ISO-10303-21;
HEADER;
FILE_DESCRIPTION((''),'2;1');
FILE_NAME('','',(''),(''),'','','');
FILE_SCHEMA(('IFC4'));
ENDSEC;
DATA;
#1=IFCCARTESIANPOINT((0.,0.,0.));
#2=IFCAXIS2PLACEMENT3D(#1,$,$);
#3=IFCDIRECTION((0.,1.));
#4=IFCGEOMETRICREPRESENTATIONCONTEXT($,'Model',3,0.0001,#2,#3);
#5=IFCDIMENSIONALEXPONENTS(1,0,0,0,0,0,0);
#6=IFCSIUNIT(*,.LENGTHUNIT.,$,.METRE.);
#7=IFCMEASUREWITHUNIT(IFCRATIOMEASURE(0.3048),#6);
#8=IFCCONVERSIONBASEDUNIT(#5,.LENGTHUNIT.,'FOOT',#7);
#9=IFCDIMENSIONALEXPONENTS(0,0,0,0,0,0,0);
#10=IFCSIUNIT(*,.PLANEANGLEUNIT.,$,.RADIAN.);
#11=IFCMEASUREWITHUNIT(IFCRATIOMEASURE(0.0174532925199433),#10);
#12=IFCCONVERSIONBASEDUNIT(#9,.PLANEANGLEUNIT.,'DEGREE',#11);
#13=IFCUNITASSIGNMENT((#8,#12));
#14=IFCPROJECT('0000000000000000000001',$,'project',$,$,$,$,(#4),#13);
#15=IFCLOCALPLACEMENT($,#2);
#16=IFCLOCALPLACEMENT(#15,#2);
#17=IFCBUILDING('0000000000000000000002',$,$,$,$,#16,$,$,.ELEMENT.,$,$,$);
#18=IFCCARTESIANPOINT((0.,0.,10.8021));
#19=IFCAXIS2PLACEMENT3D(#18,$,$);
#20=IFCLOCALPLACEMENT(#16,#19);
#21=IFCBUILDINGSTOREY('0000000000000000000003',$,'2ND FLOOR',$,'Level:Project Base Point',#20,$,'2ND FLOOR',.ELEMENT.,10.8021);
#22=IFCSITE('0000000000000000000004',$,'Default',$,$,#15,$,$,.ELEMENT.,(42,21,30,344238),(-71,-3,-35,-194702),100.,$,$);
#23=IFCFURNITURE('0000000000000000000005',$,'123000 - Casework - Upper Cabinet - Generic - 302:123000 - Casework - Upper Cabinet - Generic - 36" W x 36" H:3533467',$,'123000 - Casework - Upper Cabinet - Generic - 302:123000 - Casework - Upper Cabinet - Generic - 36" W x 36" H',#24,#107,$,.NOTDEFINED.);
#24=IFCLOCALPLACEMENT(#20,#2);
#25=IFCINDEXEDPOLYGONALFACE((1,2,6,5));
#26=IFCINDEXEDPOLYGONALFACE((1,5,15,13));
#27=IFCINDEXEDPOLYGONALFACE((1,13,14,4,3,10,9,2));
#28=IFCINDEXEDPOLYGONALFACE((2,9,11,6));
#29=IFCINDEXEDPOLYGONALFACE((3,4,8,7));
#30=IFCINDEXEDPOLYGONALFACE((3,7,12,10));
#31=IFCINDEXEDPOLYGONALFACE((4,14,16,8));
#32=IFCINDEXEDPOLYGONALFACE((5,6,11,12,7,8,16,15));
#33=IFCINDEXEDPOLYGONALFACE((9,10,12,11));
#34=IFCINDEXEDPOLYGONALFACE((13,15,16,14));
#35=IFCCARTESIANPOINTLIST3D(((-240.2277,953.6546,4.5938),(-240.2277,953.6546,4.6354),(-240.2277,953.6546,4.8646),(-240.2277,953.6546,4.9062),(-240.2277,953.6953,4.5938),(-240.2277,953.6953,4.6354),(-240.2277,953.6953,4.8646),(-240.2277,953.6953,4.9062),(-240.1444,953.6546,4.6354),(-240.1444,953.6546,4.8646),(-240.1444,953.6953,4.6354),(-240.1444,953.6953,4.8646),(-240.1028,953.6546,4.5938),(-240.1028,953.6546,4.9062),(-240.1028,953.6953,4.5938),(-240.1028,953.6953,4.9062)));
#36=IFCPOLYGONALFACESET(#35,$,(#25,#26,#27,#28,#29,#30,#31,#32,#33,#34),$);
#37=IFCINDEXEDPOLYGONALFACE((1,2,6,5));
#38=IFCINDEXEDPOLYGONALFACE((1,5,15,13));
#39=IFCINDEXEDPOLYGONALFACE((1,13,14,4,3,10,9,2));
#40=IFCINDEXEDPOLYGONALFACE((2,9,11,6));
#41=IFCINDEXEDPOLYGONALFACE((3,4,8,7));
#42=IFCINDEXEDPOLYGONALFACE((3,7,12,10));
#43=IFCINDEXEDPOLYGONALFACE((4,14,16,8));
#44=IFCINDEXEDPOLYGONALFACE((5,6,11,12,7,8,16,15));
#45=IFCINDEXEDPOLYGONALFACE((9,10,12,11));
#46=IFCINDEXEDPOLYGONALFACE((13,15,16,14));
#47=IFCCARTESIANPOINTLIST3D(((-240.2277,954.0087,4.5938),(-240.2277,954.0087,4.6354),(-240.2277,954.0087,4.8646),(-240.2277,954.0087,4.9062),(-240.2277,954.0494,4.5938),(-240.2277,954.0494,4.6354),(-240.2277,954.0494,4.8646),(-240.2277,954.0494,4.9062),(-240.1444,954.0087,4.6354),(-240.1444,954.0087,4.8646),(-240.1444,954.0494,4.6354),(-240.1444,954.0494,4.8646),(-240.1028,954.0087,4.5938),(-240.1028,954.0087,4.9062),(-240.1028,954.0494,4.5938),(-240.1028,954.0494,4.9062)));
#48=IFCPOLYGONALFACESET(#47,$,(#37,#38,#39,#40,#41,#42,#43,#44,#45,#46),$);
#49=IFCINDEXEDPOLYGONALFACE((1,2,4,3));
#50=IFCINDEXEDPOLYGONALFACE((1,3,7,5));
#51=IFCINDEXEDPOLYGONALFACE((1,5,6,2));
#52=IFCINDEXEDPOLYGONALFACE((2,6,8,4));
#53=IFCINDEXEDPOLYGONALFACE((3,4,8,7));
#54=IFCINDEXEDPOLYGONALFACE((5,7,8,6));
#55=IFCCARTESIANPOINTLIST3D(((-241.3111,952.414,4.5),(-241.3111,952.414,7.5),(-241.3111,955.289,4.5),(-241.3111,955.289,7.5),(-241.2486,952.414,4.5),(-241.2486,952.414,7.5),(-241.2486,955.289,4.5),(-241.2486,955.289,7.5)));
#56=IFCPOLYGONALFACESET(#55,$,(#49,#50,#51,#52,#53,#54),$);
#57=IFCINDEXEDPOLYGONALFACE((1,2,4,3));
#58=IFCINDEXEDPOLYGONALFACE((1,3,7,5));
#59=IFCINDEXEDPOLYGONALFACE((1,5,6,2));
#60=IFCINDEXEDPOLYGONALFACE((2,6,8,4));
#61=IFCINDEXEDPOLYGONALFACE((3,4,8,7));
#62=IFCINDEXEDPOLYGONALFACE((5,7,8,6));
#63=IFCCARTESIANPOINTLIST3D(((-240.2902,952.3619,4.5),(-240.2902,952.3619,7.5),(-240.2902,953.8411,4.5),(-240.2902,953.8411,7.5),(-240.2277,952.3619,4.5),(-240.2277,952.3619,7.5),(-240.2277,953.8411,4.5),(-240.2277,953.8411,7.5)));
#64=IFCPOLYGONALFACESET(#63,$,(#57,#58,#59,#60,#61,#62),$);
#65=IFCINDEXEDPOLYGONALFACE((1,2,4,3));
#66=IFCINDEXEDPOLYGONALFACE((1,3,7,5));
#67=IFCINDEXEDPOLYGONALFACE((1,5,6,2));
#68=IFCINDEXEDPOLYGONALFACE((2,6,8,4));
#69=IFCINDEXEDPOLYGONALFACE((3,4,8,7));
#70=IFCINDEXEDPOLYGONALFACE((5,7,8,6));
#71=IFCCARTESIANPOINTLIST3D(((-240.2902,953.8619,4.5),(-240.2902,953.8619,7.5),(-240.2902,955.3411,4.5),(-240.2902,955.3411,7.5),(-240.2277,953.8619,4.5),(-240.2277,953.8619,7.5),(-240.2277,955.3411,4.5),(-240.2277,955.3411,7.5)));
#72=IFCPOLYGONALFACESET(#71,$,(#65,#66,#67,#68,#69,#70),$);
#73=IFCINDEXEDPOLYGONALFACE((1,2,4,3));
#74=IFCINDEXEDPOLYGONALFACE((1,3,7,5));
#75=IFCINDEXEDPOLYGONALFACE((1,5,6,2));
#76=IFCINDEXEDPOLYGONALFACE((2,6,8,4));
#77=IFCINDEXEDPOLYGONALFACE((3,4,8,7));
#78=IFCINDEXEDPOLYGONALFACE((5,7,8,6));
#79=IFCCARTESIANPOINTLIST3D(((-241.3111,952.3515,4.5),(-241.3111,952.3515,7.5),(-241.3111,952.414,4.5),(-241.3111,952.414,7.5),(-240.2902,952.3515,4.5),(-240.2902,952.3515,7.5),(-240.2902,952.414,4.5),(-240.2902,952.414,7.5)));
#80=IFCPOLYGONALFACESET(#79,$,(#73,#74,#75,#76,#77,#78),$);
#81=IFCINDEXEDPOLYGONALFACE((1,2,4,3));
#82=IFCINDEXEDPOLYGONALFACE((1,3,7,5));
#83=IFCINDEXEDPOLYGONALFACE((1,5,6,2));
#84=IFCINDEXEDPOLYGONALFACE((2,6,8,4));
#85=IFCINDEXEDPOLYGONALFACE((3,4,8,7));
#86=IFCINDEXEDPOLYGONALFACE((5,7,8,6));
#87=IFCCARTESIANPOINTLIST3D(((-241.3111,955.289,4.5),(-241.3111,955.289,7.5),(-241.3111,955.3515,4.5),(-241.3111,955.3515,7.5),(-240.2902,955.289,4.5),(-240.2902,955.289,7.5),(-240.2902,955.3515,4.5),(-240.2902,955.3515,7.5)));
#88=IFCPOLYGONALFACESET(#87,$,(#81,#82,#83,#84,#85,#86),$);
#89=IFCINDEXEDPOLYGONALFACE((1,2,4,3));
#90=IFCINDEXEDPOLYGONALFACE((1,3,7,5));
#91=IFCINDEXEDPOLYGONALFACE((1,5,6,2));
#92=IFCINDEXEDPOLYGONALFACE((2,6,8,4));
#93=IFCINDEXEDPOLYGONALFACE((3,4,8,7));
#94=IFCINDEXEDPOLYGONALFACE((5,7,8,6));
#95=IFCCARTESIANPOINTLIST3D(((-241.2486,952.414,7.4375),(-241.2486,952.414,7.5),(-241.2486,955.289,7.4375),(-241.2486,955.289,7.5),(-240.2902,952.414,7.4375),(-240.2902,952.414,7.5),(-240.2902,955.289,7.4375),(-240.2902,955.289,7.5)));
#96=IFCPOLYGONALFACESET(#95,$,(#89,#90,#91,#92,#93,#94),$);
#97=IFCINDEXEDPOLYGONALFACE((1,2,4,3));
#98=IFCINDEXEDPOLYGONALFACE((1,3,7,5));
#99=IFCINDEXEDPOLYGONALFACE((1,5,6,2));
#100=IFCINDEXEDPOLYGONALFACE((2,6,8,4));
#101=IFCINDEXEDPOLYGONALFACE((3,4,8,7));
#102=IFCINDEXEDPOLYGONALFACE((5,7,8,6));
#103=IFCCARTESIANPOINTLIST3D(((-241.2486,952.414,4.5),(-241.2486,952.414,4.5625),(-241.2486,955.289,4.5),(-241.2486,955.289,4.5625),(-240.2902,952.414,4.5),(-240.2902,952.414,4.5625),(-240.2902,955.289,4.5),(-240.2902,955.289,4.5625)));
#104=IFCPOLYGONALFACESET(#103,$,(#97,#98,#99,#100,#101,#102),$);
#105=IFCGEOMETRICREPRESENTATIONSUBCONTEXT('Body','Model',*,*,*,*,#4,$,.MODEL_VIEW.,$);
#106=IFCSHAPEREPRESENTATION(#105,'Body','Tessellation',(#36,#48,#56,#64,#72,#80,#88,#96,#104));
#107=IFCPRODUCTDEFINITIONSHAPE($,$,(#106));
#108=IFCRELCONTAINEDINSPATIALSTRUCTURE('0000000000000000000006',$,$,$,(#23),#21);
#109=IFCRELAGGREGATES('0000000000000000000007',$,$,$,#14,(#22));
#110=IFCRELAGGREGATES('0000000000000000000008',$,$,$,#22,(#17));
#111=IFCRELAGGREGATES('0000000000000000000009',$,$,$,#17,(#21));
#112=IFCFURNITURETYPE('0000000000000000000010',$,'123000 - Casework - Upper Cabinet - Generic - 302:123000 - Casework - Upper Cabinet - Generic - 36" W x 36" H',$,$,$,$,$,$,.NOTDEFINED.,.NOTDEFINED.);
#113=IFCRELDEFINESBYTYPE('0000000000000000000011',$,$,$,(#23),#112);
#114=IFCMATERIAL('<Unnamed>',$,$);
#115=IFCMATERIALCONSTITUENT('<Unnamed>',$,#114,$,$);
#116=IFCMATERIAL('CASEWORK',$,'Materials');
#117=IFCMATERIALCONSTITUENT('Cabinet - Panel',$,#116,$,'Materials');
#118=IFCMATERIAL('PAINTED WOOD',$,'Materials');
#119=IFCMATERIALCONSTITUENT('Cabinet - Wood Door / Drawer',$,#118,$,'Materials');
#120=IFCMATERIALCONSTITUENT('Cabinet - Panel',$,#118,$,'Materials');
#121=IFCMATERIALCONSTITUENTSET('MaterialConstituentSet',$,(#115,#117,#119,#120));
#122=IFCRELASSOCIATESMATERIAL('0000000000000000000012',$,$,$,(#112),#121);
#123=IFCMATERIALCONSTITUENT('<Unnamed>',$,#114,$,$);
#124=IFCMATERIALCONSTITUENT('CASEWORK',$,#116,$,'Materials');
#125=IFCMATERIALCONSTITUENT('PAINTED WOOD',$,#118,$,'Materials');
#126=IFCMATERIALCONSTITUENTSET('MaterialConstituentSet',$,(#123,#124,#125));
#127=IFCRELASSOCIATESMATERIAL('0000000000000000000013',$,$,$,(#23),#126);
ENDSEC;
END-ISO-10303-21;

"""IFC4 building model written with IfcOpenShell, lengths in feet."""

from ifc_helpers import new_model, entity, si_unit, converted_unit, direction, frame, frame_2d, origin, origin_2d_with_axis, place, context, subcontext, project, spatial, polyline, rectangle, outline, extrude, source, transform, mapped, material, constituent, constituent_set, type_object, type_shapes, element, save


model = new_model("IFC4")

# Units and contexts
model_context = context("Model", 3, precision=0.0001, world=origin(), true_north=direction((0.0, 1.0)))
body_context = subcontext(model_context, "Body", "Model", "MODEL_VIEW")
ifc_project = project(units=[converted_unit("LENGTHUNIT", "FOOT", entity("IfcRatioMeasure", 0.3048), si_unit("LENGTHUNIT", "METRE"), dimensions=[1, 0, 0, 0, 0, 0, 0]), converted_unit("PLANEANGLEUNIT", "DEGREE", entity("IfcRatioMeasure", 0.0174532925199433), si_unit("PLANEANGLEUNIT", "RADIAN"), dimensions=[0, 0, 0, 0, 0, 0, 0])], contexts=[model_context])

# Site, building, storey
site_placement = place(None, origin())
site = spatial("IfcSite", under=ifc_project, at=site_placement, Name="Default", CompositionType="ELEMENT", RefLatitude=(42, 21, 30, 344238), RefLongitude=(-71, -3, -35, -194702), RefElevation=100.0)
building_placement = place(site_placement, origin())
building = spatial("IfcBuilding", under=site, at=building_placement, CompositionType="ELEMENT")
storey_placement = place(building_placement, frame((0.0, 0.0, 10.8021)))
storey = spatial("IfcBuildingStorey", under=building, at=storey_placement, Name="2ND FLOOR", ObjectType="Level:Project Base Point", LongName="2ND FLOOR", CompositionType="ELEMENT", Elevation=10.8021)

# Shared definitions
ifc_material_1 = material(Name="PAINTED WOOD", Category="Materials")
ifc_material_2 = material(Name="CASEWORK", Category="Materials")

# Furniture
ifc_material_3 = material(Name="<Unnamed>")
ifc_constituent_1 = constituent(ifc_material_3, Name="<Unnamed>")
ifc_constituent_2 = constituent(ifc_material_2, Name="CASEWORK", Category="Materials")
ifc_constituent_3 = constituent(ifc_material_1, Name="PAINTED WOOD", Category="Materials")
ifc_constituent_set_1 = constituent_set(constituents=[ifc_constituent_1, ifc_constituent_2, ifc_constituent_3], Name="MaterialConstituentSet")
ifc_constituent_4 = constituent(ifc_material_3, Name="<Unnamed>")
ifc_constituent_5 = constituent(ifc_material_2, Name="Cabinet - Panel", Category="Materials")
ifc_constituent_6 = constituent(ifc_material_1, Name="Cabinet - Wood Door / Drawer", Category="Materials")
ifc_constituent_7 = constituent(ifc_material_1, Name="Cabinet - Panel", Category="Materials")
ifc_constituent_set_2 = constituent_set(constituents=[ifc_constituent_4, ifc_constituent_5, ifc_constituent_6, ifc_constituent_7], Name="MaterialConstituentSet")
furniture_type_1 = type_object("IfcFurnitureType", Name="123000 - Casework - Upper Cabinet - Generic - 302:123000 - Casework - Upper Cabinet - Generic - 36\" W x 36\" H", AssemblyPlace="NOTDEFINED", PredefinedType="NOTDEFINED", material=ifc_constituent_set_2)
shared_shape_1 = source(origin(), body_context, "Body", "SweptSolid", [
    extrude(outline(polyline([(0.1146, -0.0521), (0.1562, -0.0521), (0.1562, 0.0729), (-0.1562, 0.0729), (-0.1562, -0.0521), (-0.1146, -0.0521), (-0.1146, 0.0313), (0.1146, 0.0313), (0.1146, -0.0521)])), frame((1.303, 0.0729, 0.25), z_axis=(1.0, 0.0, 0.0), x_axis=(0.0, 0.0, 1.0)), (0.0, 0.0, 1.0), 0.0407),
    extrude(outline(polyline([(0.1146, -0.0521), (0.1562, -0.0521), (0.1562, 0.0729), (-0.1562, 0.0729), (-0.1562, -0.0521), (-0.1146, -0.0521), (-0.1146, 0.0313), (0.1146, 0.0313), (0.1146, -0.0521)])), frame((1.6572, 0.0729, 0.25), z_axis=(1.0, 0.0, 0.0), x_axis=(0.0, 0.0, 1.0)), (0.0, 0.0, 1.0), 0.0407),
    extrude(rectangle(XDim=0.0625, YDim=2.875, at=origin_2d_with_axis()), frame((1.5, 1.177, 0.0), z_axis=(0.0, 0.0, 1.0), x_axis=(0.0, 1.0, 0.0)), (0.0, 0.0, 1.0), 3.0),
    extrude(rectangle(XDim=0.0625, YDim=1.4792, at=frame_2d((0.0, 0.0), x_axis=(1.0, 0.0))), frame((0.75, 0.1562, 0.0), z_axis=(0.0, 0.0, 1.0), x_axis=(0.0, -1.0, 0.0)), (0.0, 0.0, 1.0), 3.0),
    extrude(rectangle(XDim=0.0625, YDim=1.4792, at=origin_2d_with_axis()), frame((2.25, 0.1562, 0.0), z_axis=(0.0, 0.0, 1.0), x_axis=(0.0, -1.0, 0.0)), (0.0, 0.0, 1.0), 3.0),
    extrude(rectangle(XDim=0.0625, YDim=1.0208, at=origin_2d_with_axis()), frame((0.0312, 0.6979, 0.0), z_axis=(0.0, 0.0, 1.0), x_axis=(-1.0, 0.0, 0.0)), (0.0, 0.0, 1.0), 3.0),
    extrude(rectangle(XDim=0.0625, YDim=1.0208, at=origin_2d_with_axis()), frame((2.9688, 0.6979, 0.0), z_axis=(0.0, 0.0, 1.0), x_axis=(-1.0, 0.0, 0.0)), (0.0, 0.0, 1.0), 3.0),
    extrude(rectangle(XDim=2.875, YDim=0.9583, at=frame_2d((0.0, 0.0), x_axis=(1.0, 0.0))), frame((1.5, 0.6666, 2.9375), z_axis=(0.0, 0.0, 1.0), x_axis=(-1.0, 0.0, 0.0)), (0.0, 0.0, 1.0), 0.0625),
    extrude(rectangle(XDim=2.875, YDim=0.9583, at=frame_2d((0.0, 0.0), x_axis=(1.0, 0.0))), frame((1.5, 0.6666, 0.0), z_axis=(0.0, 0.0, 1.0), x_axis=(-1.0, 0.0, 0.0)), (0.0, 0.0, 1.0), 0.0625),
])
type_shapes(furniture_type_1, [shared_shape_1])
furniture_1_placement = place(storey_placement, frame((-240.1028, 952.3515, 4.5), z_axis=(0.0, 0.0, 1.0), x_axis=(0.0, 1.0, 0.0)))
element("IfcFurniture", 1, at=furniture_1_placement, inside=storey, type_object=furniture_type_1, material=ifc_constituent_set_1, Name="123000 - Casework - Upper Cabinet - Generic - 302:123000 - Casework - Upper Cabinet - Generic - 36\" W x 36\" H:3533467", ObjectType="123000 - Casework - Upper Cabinet - Generic - 302:123000 - Casework - Upper Cabinet - Generic - 36\" W x 36\" H", PredefinedType="NOTDEFINED", context=body_context, shape_type="MappedRepresentation", body=[
    mapped(shared_shape_1, transform((0.0, 0.0, 0.0), scale=1.0)),
])

save(model, "model.ifc")
